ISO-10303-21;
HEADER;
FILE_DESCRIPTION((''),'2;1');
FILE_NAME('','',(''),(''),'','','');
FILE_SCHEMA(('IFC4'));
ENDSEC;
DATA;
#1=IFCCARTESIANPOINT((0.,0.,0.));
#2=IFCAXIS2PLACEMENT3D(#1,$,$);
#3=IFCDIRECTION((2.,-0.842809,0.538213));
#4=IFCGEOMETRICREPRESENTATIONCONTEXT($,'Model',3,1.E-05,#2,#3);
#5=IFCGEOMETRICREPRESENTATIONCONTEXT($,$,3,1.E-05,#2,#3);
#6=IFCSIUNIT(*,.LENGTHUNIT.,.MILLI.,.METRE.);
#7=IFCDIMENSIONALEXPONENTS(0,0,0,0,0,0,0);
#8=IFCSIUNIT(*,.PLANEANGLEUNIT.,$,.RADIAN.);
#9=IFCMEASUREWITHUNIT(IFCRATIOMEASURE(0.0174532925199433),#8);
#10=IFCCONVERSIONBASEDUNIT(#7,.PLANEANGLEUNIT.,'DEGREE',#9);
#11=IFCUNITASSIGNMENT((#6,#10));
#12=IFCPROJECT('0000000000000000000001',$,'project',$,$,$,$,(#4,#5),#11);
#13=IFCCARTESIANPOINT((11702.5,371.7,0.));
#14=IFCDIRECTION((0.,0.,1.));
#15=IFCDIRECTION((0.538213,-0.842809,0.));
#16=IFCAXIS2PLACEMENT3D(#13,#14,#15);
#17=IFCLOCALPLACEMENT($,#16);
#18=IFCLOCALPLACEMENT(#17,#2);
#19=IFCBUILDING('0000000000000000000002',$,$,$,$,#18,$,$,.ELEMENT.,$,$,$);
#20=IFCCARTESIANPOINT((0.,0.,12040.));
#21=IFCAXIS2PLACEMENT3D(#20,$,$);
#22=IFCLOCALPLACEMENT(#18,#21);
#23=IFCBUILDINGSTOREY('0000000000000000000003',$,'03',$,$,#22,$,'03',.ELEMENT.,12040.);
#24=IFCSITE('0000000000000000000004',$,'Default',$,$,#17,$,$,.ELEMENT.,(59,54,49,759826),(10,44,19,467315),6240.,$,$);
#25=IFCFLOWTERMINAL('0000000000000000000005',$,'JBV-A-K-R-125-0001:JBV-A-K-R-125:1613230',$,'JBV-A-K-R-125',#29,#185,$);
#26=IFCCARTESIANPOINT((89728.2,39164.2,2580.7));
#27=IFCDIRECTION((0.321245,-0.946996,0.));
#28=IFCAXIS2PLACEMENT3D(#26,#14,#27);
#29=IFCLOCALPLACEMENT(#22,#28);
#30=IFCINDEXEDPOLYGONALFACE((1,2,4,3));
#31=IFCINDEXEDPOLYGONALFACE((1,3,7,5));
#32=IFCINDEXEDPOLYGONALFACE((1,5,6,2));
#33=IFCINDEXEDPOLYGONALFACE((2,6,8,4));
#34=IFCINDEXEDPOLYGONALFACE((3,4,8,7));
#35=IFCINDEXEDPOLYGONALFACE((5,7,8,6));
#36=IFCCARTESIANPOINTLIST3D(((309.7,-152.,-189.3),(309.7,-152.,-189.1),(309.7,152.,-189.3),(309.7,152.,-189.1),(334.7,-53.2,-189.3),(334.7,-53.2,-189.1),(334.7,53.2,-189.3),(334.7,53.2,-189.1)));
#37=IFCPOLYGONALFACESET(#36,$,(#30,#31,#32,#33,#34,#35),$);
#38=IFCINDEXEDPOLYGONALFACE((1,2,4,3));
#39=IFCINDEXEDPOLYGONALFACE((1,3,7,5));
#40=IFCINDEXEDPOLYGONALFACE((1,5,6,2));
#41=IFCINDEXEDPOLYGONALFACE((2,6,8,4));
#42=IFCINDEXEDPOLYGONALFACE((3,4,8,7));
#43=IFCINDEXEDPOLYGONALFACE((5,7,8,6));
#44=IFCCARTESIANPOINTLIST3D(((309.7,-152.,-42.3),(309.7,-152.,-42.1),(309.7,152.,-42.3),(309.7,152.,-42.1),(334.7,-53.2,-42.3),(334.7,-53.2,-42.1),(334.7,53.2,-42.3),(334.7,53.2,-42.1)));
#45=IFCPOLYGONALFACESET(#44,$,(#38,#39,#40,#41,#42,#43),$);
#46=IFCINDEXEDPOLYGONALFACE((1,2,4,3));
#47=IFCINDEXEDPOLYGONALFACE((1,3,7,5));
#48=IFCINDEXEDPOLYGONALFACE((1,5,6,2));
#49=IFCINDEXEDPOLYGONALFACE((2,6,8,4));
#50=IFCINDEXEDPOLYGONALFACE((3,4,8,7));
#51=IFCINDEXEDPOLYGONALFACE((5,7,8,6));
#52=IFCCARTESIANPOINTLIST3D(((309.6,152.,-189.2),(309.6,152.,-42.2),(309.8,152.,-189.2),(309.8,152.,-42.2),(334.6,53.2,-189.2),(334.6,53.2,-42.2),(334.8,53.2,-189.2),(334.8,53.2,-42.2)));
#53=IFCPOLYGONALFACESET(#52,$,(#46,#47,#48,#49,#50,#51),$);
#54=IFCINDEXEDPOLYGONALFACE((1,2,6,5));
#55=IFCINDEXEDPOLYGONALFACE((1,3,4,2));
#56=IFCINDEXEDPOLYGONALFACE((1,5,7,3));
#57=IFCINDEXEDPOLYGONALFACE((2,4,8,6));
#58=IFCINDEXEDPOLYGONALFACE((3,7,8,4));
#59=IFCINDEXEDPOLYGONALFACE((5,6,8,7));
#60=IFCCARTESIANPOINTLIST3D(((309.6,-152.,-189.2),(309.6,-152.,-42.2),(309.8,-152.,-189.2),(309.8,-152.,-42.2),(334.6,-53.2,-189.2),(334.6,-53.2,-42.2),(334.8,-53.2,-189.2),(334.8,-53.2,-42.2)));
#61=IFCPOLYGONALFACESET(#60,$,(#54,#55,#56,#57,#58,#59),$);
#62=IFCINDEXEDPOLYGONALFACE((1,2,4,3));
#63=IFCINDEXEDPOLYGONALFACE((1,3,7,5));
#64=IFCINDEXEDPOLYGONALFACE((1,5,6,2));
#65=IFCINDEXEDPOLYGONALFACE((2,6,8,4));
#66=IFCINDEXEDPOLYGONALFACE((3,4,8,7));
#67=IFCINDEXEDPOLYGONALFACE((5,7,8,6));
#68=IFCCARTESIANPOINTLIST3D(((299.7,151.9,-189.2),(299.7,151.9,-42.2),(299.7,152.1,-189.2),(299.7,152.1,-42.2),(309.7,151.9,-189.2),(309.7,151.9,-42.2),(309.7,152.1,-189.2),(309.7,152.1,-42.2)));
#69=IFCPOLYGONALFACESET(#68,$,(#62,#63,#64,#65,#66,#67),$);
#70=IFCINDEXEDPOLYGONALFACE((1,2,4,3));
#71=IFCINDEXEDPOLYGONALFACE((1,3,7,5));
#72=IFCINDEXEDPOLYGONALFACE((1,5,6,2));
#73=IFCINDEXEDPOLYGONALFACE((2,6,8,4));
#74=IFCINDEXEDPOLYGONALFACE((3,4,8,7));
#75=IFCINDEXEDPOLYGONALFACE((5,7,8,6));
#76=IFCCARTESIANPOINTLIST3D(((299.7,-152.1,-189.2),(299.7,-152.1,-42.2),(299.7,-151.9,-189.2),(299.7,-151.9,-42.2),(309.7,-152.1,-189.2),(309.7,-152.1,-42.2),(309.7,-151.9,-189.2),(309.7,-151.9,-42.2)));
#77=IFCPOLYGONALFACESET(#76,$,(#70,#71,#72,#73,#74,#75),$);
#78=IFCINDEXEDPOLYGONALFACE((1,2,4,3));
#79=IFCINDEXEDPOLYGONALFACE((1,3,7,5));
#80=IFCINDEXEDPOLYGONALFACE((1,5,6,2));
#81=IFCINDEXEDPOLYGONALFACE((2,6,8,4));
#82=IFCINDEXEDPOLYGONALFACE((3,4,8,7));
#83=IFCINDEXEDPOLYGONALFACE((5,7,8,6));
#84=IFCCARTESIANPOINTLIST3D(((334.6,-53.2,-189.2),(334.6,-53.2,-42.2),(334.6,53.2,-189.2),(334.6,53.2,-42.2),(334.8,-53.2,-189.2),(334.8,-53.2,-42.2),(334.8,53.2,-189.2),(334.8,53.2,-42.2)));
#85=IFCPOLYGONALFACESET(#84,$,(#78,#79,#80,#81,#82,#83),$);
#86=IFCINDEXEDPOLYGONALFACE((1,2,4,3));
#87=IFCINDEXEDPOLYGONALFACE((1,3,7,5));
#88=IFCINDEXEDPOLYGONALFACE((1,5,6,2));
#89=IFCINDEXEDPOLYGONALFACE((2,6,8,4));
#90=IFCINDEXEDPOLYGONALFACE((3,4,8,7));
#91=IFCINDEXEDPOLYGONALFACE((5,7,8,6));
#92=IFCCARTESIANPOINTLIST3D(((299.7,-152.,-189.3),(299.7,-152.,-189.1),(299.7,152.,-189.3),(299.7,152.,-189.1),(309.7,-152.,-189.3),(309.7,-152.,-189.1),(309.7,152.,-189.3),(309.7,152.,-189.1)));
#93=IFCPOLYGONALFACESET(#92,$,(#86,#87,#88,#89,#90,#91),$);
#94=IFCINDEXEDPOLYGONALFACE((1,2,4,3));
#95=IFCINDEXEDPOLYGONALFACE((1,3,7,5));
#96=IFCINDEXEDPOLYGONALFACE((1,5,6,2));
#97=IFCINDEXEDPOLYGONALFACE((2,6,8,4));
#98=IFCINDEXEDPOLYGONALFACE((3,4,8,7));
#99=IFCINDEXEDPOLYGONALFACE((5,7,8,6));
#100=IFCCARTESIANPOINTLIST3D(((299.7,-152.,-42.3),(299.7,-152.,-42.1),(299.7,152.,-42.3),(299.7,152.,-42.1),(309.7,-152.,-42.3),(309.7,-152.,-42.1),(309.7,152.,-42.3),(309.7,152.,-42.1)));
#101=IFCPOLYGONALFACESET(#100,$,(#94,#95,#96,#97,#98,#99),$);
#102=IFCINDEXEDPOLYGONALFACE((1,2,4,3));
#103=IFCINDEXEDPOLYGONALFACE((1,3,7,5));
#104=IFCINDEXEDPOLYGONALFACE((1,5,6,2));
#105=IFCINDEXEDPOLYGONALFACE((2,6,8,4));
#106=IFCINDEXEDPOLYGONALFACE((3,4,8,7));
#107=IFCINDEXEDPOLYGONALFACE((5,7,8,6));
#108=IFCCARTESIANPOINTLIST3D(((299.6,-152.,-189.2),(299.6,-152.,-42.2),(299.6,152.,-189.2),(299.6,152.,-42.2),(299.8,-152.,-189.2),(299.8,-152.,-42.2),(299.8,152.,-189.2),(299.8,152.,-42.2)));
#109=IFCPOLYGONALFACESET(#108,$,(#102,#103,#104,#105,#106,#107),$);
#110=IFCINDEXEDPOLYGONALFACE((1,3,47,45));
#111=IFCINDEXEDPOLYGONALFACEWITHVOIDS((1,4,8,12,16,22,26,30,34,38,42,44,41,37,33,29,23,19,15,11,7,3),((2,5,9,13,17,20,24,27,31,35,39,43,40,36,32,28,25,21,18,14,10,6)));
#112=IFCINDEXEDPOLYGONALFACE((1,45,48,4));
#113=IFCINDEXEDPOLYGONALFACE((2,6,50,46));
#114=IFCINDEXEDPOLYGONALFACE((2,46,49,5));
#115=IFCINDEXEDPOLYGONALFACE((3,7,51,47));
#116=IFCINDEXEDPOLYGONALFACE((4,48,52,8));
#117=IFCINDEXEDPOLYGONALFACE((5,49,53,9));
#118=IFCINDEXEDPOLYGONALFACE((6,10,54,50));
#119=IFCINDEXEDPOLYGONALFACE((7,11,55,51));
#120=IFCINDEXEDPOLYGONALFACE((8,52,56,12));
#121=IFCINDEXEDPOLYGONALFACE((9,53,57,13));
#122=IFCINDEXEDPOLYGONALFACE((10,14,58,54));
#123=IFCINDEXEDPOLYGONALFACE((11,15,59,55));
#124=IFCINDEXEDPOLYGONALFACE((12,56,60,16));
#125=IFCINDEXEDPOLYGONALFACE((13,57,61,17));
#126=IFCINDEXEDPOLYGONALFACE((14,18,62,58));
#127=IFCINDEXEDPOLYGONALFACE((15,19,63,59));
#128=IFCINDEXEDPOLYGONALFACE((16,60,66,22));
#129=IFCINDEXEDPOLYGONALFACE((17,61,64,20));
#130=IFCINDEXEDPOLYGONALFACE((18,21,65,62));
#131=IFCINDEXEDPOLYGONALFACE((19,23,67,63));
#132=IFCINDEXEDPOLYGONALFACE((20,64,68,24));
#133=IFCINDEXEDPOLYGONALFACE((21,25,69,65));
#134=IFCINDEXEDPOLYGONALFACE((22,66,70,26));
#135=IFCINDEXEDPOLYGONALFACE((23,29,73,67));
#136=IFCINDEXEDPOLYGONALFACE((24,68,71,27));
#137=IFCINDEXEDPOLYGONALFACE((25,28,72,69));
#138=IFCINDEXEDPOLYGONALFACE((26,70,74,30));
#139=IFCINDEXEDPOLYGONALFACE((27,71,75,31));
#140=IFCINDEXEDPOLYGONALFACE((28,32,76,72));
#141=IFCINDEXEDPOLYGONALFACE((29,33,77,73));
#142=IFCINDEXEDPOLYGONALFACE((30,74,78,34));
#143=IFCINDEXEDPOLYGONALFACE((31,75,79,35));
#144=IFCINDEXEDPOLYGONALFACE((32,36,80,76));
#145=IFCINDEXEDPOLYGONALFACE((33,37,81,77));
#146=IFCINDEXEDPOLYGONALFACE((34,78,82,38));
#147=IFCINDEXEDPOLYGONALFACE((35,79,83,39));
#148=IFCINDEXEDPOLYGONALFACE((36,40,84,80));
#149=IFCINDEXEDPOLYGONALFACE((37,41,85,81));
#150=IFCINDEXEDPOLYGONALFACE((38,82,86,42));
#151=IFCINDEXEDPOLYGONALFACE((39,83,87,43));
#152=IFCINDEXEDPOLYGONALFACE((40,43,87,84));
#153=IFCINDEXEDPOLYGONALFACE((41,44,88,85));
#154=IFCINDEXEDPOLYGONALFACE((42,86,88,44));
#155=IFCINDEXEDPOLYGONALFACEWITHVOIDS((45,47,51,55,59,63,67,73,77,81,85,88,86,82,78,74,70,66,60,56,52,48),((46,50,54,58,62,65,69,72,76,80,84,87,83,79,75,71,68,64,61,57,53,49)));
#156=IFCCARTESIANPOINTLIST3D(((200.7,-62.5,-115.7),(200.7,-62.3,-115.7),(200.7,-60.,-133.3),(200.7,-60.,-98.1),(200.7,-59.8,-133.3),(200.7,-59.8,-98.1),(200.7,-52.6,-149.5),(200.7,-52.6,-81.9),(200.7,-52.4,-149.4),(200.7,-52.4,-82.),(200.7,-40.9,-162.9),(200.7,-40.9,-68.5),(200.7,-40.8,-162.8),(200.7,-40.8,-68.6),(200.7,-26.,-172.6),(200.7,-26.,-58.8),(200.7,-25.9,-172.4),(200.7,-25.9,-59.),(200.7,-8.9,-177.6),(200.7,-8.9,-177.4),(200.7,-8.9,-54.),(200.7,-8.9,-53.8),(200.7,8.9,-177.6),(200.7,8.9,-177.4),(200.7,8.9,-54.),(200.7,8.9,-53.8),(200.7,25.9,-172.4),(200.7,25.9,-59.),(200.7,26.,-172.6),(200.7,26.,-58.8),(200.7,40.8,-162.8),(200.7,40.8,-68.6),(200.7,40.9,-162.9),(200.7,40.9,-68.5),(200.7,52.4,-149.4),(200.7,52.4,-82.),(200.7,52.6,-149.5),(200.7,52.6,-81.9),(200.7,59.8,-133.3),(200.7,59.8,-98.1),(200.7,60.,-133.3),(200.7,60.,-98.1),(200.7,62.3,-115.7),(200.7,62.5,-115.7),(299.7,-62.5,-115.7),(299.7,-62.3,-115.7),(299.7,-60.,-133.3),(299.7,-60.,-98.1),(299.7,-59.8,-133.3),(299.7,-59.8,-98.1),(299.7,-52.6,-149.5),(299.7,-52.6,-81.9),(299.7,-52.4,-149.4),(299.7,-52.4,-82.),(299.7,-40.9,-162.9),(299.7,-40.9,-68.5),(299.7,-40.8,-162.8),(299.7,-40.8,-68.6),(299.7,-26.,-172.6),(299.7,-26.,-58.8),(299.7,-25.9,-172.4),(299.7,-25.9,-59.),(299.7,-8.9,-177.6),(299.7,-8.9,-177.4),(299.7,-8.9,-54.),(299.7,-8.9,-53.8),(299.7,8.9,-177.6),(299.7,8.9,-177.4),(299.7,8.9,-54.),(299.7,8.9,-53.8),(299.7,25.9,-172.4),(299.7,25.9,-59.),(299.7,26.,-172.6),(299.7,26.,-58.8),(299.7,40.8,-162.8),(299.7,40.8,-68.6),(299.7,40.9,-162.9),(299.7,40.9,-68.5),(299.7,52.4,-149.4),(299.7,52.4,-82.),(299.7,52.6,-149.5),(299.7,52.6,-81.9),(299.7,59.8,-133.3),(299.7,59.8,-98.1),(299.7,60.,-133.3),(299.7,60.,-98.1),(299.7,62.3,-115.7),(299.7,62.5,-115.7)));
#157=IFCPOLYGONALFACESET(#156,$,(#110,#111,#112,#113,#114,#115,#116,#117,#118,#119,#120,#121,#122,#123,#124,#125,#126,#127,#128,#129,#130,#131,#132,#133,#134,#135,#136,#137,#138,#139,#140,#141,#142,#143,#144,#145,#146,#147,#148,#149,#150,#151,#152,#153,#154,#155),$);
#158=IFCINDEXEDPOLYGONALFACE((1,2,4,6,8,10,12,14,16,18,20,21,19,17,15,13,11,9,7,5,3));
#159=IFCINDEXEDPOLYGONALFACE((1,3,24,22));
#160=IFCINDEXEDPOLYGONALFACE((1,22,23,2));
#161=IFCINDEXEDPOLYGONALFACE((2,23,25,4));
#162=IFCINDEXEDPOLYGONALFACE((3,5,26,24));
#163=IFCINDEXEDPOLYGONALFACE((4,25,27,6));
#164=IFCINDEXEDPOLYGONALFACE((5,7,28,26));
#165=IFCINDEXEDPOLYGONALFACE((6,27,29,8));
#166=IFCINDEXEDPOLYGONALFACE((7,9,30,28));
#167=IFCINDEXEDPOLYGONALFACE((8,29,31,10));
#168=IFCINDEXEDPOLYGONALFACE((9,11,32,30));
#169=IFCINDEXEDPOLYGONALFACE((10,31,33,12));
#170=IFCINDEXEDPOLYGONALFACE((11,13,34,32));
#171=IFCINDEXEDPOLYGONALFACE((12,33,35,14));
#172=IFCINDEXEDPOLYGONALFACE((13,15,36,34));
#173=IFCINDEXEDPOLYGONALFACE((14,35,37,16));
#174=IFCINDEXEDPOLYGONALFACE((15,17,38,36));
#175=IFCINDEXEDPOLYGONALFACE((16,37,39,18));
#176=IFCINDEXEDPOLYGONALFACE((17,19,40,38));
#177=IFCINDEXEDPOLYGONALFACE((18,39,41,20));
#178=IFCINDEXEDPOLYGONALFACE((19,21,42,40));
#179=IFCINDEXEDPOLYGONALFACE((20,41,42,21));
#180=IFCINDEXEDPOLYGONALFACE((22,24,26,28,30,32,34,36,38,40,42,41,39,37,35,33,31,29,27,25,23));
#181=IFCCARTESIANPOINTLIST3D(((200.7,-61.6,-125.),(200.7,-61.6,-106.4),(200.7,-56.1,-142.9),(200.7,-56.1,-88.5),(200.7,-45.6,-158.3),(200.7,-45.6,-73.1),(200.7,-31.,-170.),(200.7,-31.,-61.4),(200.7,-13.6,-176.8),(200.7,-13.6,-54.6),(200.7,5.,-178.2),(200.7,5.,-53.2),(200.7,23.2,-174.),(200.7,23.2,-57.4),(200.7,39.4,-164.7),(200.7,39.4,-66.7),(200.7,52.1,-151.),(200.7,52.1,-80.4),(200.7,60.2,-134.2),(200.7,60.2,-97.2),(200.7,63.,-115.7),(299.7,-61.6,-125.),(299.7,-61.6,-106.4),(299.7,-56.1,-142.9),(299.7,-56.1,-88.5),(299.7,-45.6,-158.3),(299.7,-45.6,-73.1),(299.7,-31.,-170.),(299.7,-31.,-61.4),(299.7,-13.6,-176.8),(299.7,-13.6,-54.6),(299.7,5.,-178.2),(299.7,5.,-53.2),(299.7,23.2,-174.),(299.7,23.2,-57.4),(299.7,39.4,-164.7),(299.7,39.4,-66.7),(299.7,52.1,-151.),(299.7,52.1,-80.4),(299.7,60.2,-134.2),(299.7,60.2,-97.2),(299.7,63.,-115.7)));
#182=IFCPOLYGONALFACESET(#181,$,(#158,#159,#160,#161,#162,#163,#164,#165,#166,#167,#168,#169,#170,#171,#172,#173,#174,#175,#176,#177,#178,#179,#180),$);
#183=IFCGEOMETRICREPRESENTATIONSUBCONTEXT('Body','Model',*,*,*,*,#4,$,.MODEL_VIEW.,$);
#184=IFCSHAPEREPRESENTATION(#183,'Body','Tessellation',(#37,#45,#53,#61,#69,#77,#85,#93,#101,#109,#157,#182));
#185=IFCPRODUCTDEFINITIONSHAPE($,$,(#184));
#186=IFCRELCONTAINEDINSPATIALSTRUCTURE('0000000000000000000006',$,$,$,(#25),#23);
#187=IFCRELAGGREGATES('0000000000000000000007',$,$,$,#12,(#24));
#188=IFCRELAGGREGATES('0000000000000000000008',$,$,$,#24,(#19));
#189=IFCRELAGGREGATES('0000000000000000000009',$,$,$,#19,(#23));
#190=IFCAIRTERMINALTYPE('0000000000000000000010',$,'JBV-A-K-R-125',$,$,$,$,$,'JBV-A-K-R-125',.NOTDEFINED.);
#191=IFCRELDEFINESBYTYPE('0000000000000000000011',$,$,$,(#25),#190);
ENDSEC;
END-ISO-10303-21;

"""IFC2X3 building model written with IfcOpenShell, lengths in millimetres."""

from ifc_helpers import new_model, entity, si_unit, converted_unit, direction, frame, frame_2d, origin, origin_2d_with_axis, place, context, subcontext, project, spatial, polyline, circle_curve, parameter, trimmed, segment, composite_curve, rectangle, circle, outline, extrude, source, transform, mapped, type_object, type_shapes, element, save


model = new_model("IFC2X3")

# Units and contexts
model_context = context("Model", 3, precision=1e-05, world=origin(), true_north=direction((2.0, -0.842809, 0.538213)))
context_of_model = context(None, 3, precision=1e-05, world=origin(), true_north=direction((2.0, -0.842809, 0.538213)))
body_context = subcontext(model_context, "Body", "Model", "MODEL_VIEW")
ifc_project = project(units=[si_unit("LENGTHUNIT", "METRE", prefix="MILLI"), converted_unit("PLANEANGLEUNIT", "DEGREE", entity("IfcRatioMeasure", 0.0174532925199433), si_unit("PLANEANGLEUNIT", "RADIAN"), dimensions=[0, 0, 0, 0, 0, 0, 0])], contexts=[model_context, context_of_model])

# Site, building, storey
site_placement = place(None, frame((11702.5, 371.7, 0.0), z_axis=(0.0, 0.0, 1.0), x_axis=(0.538213, -0.842809, 0.0)))
site = spatial("IfcSite", under=ifc_project, at=site_placement, Name="Default", CompositionType="ELEMENT", RefLatitude=(59, 54, 49, 759826), RefLongitude=(10, 44, 19, 467315), RefElevation=6240.0)
building_placement = place(site_placement, origin())
building = spatial("IfcBuilding", under=site, at=building_placement, CompositionType="ELEMENT")
storey_placement = place(building_placement, frame((0.0, 0.0, 12040.0)))
storey = spatial("IfcBuildingStorey", under=building, at=storey_placement, Name="03", LongName="03", CompositionType="ELEMENT", Elevation=12040.0)

# Flow terminal
air_terminal_type_1 = type_object("IfcAirTerminalType", Name="JBV-A-K-R-125", ElementType="JBV-A-K-R-125", PredefinedType="NOTDEFINED")
shared_shape_1 = source(origin(), body_context, "Body", "SweptSolid", [
    extrude(outline(polyline([(-152.0, -12.5), (152.0, -12.5), (53.2, 12.5), (-53.2, 12.5), (-152.0, -12.5)])), frame((322.2, 0.0, -189.3), z_axis=(0.0, 0.0, 1.0), x_axis=(0.0, -1.0, 0.0)), (0.0, 0.0, 1.0), 0.2),
    extrude(outline(polyline([(-152.0, -12.5), (152.0, -12.5), (53.2, 12.5), (-53.2, 12.5), (-152.0, -12.5)])), frame((322.2, 0.0, -42.3), z_axis=(0.0, 0.0, 1.0), x_axis=(0.0, -1.0, 0.0)), (0.0, 0.0, 1.0), 0.2),
    extrude(rectangle(XDim=0.2, YDim=101.9, at=frame_2d((0.0, 0.0), x_axis=(1.0, 0.0))), frame((322.2, 102.6, -189.2), z_axis=(0.0, 0.0, 1.0), x_axis=(0.969446, 0.245305, 0.0)), (0.0, 0.0, 1.0), 147.0),
    extrude(rectangle(XDim=0.2, YDim=101.9, at=frame_2d((0.0, 0.0), x_axis=(1.0, 0.0))), frame((322.2, -102.6, -189.2), z_axis=(0.0, 0.0, 1.0), x_axis=(-0.969446, 0.245305, 0.0)), (0.0, 0.0, 1.0), 147.0),
    extrude(rectangle(XDim=0.2, YDim=10.0, at=frame_2d((0.0, 0.0), x_axis=(1.0, 0.0))), frame((304.7, 152.0, -189.2), z_axis=(0.0, 0.0, 1.0), x_axis=(0.0, 1.0, 0.0)), (0.0, 0.0, 1.0), 147.0),
    extrude(rectangle(XDim=0.2, YDim=10.0, at=frame_2d((0.0, 0.0), x_axis=(1.0, 0.0))), frame((304.7, -152.0, -189.2), z_axis=(0.0, 0.0, 1.0), x_axis=(0.0, 1.0, 0.0)), (0.0, 0.0, 1.0), 147.0),
    extrude(rectangle(XDim=0.2, YDim=106.4, at=frame_2d((0.0, 0.0), x_axis=(1.0, 0.0))), frame((334.7, 0.0, -189.2)), (0.0, 0.0, 1.0), 147.0),
    extrude(rectangle(XDim=304.0, YDim=10.0, at=frame_2d((0.0, 0.0), x_axis=(1.0, 0.0))), frame((304.7, 0.0, -189.3), z_axis=(0.0, 0.0, 1.0), x_axis=(0.0, -1.0, 0.0)), (0.0, 0.0, 1.0), 0.2),
    extrude(rectangle(XDim=304.0, YDim=10.0, at=frame_2d((0.0, 0.0), x_axis=(1.0, 0.0))), frame((304.7, 0.0, -42.3), z_axis=(0.0, 0.0, 1.0), x_axis=(0.0, -1.0, 0.0)), (0.0, 0.0, 1.0), 0.2),
    extrude(rectangle(XDim=0.2, YDim=304.0, at=frame_2d((0.0, 0.0), x_axis=(1.0, 0.0))), frame((299.7, 0.0, -189.2)), (0.0, 0.0, 1.0), 147.0),
    extrude(outline(composite_curve([segment(trimmed(circle_curve(origin_2d_with_axis(), 62.5), [parameter(0.0)], [parameter(180.0)], True, "PARAMETER"), True, "CONTINUOUS"), segment(trimmed(circle_curve(origin_2d_with_axis(), 62.5), [parameter(180.0)], [parameter(360.0)], True, "PARAMETER"), True, "CONTINUOUS")], self_intersect=False), holes=[composite_curve([segment(trimmed(circle_curve(origin_2d_with_axis(), 62.3), [parameter(180.0)], [parameter(360.0)], True, "PARAMETER"), False, "CONTINUOUS"), segment(trimmed(circle_curve(origin_2d_with_axis(), 62.3), [parameter(0.0)], [parameter(180.0)], True, "PARAMETER"), False, "CONTINUOUS")], self_intersect=False)]), frame((200.7, 0.0, -115.7), z_axis=(1.0, 0.0, 0.0), x_axis=(0.0, 1.0, 0.0)), (0.0, 0.0, 1.0), 99.0),
    extrude(circle(Radius=62.6, at=frame_2d((0.0, 0.0), x_axis=(1.0, 0.0))), frame((200.7, 0.3, -115.7), z_axis=(1.0, 0.0, 0.0), x_axis=(0.0, 1.0, 0.0)), (0.0, 0.0, 1.0), 99.0),
])
type_shapes(air_terminal_type_1, [shared_shape_1])
for number, where, z_axis, x_axis, name in (
    (1, (89728.2, 39164.2, 2580.7), (0.0, 0.0, 1.0), (0.321245, -0.946996, 0.0), "JBV-A-K-R-125-0001:JBV-A-K-R-125:1613230"),
):
    element("IfcFlowTerminal", number, at=place(storey_placement, frame(where, z_axis=z_axis, x_axis=x_axis)), inside=storey, type_object=air_terminal_type_1, Name=name, ObjectType="JBV-A-K-R-125", context=body_context, shape_type="MappedRepresentation", body=[
        mapped(shared_shape_1, transform((0.0, 0.0, 0.0), scale=1.0)),
    ])

save(model, "model.ifc")
